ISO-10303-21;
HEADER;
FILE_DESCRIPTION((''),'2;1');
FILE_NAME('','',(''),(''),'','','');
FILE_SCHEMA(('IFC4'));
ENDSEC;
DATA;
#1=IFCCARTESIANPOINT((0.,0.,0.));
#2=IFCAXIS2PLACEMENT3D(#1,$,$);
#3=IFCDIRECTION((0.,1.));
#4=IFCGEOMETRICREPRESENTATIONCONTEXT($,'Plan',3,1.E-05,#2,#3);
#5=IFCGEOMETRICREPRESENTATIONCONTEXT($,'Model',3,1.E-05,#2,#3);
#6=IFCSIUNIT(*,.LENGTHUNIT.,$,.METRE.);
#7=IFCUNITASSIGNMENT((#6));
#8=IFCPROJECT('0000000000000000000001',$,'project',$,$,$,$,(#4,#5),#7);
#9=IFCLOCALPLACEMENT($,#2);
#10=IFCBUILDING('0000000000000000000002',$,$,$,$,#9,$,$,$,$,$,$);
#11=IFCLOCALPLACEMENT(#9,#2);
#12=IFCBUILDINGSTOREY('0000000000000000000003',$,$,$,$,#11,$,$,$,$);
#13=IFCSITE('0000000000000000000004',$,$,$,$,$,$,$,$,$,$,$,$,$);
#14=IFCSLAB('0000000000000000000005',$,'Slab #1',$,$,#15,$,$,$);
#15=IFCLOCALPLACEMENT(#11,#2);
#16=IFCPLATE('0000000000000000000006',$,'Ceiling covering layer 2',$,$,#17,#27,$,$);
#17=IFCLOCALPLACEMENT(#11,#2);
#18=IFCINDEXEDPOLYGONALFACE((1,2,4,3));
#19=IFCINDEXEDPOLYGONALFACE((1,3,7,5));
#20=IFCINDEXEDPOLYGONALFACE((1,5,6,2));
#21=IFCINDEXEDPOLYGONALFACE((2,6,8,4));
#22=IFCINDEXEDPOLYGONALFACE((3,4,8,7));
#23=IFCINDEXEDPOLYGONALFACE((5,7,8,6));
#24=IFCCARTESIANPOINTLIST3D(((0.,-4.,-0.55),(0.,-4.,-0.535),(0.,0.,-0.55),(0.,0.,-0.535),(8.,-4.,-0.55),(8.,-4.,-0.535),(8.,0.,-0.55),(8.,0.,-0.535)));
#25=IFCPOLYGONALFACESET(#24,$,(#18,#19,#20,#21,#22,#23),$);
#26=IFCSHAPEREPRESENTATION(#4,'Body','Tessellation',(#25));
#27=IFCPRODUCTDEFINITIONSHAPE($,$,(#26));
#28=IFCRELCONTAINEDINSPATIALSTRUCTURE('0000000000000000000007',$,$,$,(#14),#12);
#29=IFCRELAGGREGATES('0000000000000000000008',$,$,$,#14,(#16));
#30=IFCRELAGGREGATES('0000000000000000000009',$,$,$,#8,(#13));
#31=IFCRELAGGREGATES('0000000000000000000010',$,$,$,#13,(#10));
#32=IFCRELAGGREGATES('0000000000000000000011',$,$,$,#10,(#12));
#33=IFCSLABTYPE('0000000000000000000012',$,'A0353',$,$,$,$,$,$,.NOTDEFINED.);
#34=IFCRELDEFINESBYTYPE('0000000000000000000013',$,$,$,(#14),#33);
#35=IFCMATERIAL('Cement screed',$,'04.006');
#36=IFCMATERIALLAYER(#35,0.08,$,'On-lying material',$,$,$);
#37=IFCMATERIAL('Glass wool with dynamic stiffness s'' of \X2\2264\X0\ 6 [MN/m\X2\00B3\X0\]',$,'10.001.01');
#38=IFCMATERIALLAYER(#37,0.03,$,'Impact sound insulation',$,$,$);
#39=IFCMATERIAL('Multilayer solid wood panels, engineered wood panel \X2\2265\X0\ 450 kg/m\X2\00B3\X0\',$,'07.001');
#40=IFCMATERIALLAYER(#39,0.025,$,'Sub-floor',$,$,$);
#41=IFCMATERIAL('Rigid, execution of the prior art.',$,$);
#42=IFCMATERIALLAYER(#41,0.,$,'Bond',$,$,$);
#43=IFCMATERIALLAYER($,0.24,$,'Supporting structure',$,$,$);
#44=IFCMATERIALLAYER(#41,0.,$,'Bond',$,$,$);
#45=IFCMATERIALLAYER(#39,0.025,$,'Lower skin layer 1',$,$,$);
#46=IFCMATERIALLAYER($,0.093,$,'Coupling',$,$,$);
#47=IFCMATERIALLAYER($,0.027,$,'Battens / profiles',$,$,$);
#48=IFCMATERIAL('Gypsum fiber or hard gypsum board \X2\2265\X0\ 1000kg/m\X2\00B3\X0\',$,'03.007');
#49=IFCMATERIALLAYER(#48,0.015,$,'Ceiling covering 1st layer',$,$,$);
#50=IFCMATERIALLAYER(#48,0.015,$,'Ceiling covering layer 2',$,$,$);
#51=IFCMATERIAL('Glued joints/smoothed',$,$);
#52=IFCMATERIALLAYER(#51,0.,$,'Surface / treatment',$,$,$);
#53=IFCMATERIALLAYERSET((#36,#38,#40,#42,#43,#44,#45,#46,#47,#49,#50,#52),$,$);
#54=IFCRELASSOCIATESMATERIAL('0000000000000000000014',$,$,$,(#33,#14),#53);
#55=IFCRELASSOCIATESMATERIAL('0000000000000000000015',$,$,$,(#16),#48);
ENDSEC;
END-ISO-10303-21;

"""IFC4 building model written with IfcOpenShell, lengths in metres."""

from ifc_helpers import new_model, si_unit, direction, frame, frame_2d, origin, place, context, project, spatial, rectangle, extrude, material, layer, layer_set, type_object, element, aggregate, save


model = new_model("IFC4")

# Units and contexts
plan_context = context("Plan", 3, precision=1e-05, world=origin(), true_north=direction((0.0, 1.0)))
model_context = context("Model", 3, precision=1e-05, world=origin(), true_north=direction((0.0, 1.0)))
ifc_project = project(units=[si_unit("LENGTHUNIT", "METRE")], contexts=[plan_context, model_context])

# Site, building, storey
site = spatial("IfcSite", under=ifc_project)
building_placement = place(None, origin())
building = spatial("IfcBuilding", under=site, at=building_placement)
storey_placement = place(building_placement, origin())
storey = spatial("IfcBuildingStorey", under=building, at=storey_placement)

# Slab, plate
ifc_material_1 = material(Name="Cement screed", Category="04.006")
ifc_layer_1 = layer(ifc_material_1, 0.08, Name="On-lying material")
ifc_material_2 = material(Name="Glass wool with dynamic stiffness s' of ≤ 6 [MN/m³]", Category="10.001.01")
ifc_layer_2 = layer(ifc_material_2, 0.03, Name="Impact sound insulation")
ifc_material_3 = material(Name="Multilayer solid wood panels, engineered wood panel ≥ 450 kg/m³", Category="07.001")
ifc_layer_3 = layer(ifc_material_3, 0.025, Name="Sub-floor")
ifc_material_4 = material(Name="Rigid, execution of the prior art.")
ifc_layer_4 = layer(ifc_material_4, 0.0, Name="Bond")
ifc_layer_5 = layer(None, 0.24, Name="Supporting structure")
ifc_layer_6 = layer(ifc_material_4, 0.0, Name="Bond")
ifc_layer_7 = layer(ifc_material_3, 0.025, Name="Lower skin layer 1")
ifc_layer_8 = layer(None, 0.093, Name="Coupling")
ifc_layer_9 = layer(None, 0.027, Name="Battens / profiles")
ifc_material_5 = material(Name="Gypsum fiber or hard gypsum board ≥ 1000kg/m³", Category="03.007")
ifc_layer_10 = layer(ifc_material_5, 0.015, Name="Ceiling covering 1st layer")
ifc_layer_11 = layer(ifc_material_5, 0.015, Name="Ceiling covering layer 2")
ifc_material_6 = material(Name="Glued joints/smoothed")
ifc_layer_12 = layer(ifc_material_6, 0.0, Name="Surface / treatment")
ifc_layer_set = layer_set([ifc_layer_1, ifc_layer_2, ifc_layer_3, ifc_layer_4, ifc_layer_5, ifc_layer_6, ifc_layer_7, ifc_layer_8, ifc_layer_9, ifc_layer_10, ifc_layer_11, ifc_layer_12])
slab_type = type_object("IfcSlabType", Name="A0353", PredefinedType="NOTDEFINED", material=ifc_layer_set)
slab_placement = place(None, frame((0.0, 0.0, 0.0), z_axis=(0.0, 0.0, -1.0), x_axis=(1.0, 0.0, 0.0)))
slab = element("IfcSlab", 1, at=slab_placement, inside=storey, type_object=slab_type, material=ifc_layer_set, Name="Slab #1")
plate_1_placement = place(slab_placement, origin())
plate_1 = element("IfcPlate", 2, at=plate_1_placement, material=ifc_material_5, Name="Ceiling covering layer 2", context=plan_context, shape_type="SweptSolid", body=[
    extrude(rectangle(XDim=8.0, YDim=4.0, at=frame_2d((4.0, 2.0), x_axis=(1.0, 0.0))), frame((0.0, 0.0, 0.535), z_axis=(0.0, 0.0, 1.0), x_axis=(1.0, 0.0, 0.0)), (0.0, 0.0, 1.0), 0.015),
])
aggregate(slab, [plate_1])

save(model, "model.ifc")
